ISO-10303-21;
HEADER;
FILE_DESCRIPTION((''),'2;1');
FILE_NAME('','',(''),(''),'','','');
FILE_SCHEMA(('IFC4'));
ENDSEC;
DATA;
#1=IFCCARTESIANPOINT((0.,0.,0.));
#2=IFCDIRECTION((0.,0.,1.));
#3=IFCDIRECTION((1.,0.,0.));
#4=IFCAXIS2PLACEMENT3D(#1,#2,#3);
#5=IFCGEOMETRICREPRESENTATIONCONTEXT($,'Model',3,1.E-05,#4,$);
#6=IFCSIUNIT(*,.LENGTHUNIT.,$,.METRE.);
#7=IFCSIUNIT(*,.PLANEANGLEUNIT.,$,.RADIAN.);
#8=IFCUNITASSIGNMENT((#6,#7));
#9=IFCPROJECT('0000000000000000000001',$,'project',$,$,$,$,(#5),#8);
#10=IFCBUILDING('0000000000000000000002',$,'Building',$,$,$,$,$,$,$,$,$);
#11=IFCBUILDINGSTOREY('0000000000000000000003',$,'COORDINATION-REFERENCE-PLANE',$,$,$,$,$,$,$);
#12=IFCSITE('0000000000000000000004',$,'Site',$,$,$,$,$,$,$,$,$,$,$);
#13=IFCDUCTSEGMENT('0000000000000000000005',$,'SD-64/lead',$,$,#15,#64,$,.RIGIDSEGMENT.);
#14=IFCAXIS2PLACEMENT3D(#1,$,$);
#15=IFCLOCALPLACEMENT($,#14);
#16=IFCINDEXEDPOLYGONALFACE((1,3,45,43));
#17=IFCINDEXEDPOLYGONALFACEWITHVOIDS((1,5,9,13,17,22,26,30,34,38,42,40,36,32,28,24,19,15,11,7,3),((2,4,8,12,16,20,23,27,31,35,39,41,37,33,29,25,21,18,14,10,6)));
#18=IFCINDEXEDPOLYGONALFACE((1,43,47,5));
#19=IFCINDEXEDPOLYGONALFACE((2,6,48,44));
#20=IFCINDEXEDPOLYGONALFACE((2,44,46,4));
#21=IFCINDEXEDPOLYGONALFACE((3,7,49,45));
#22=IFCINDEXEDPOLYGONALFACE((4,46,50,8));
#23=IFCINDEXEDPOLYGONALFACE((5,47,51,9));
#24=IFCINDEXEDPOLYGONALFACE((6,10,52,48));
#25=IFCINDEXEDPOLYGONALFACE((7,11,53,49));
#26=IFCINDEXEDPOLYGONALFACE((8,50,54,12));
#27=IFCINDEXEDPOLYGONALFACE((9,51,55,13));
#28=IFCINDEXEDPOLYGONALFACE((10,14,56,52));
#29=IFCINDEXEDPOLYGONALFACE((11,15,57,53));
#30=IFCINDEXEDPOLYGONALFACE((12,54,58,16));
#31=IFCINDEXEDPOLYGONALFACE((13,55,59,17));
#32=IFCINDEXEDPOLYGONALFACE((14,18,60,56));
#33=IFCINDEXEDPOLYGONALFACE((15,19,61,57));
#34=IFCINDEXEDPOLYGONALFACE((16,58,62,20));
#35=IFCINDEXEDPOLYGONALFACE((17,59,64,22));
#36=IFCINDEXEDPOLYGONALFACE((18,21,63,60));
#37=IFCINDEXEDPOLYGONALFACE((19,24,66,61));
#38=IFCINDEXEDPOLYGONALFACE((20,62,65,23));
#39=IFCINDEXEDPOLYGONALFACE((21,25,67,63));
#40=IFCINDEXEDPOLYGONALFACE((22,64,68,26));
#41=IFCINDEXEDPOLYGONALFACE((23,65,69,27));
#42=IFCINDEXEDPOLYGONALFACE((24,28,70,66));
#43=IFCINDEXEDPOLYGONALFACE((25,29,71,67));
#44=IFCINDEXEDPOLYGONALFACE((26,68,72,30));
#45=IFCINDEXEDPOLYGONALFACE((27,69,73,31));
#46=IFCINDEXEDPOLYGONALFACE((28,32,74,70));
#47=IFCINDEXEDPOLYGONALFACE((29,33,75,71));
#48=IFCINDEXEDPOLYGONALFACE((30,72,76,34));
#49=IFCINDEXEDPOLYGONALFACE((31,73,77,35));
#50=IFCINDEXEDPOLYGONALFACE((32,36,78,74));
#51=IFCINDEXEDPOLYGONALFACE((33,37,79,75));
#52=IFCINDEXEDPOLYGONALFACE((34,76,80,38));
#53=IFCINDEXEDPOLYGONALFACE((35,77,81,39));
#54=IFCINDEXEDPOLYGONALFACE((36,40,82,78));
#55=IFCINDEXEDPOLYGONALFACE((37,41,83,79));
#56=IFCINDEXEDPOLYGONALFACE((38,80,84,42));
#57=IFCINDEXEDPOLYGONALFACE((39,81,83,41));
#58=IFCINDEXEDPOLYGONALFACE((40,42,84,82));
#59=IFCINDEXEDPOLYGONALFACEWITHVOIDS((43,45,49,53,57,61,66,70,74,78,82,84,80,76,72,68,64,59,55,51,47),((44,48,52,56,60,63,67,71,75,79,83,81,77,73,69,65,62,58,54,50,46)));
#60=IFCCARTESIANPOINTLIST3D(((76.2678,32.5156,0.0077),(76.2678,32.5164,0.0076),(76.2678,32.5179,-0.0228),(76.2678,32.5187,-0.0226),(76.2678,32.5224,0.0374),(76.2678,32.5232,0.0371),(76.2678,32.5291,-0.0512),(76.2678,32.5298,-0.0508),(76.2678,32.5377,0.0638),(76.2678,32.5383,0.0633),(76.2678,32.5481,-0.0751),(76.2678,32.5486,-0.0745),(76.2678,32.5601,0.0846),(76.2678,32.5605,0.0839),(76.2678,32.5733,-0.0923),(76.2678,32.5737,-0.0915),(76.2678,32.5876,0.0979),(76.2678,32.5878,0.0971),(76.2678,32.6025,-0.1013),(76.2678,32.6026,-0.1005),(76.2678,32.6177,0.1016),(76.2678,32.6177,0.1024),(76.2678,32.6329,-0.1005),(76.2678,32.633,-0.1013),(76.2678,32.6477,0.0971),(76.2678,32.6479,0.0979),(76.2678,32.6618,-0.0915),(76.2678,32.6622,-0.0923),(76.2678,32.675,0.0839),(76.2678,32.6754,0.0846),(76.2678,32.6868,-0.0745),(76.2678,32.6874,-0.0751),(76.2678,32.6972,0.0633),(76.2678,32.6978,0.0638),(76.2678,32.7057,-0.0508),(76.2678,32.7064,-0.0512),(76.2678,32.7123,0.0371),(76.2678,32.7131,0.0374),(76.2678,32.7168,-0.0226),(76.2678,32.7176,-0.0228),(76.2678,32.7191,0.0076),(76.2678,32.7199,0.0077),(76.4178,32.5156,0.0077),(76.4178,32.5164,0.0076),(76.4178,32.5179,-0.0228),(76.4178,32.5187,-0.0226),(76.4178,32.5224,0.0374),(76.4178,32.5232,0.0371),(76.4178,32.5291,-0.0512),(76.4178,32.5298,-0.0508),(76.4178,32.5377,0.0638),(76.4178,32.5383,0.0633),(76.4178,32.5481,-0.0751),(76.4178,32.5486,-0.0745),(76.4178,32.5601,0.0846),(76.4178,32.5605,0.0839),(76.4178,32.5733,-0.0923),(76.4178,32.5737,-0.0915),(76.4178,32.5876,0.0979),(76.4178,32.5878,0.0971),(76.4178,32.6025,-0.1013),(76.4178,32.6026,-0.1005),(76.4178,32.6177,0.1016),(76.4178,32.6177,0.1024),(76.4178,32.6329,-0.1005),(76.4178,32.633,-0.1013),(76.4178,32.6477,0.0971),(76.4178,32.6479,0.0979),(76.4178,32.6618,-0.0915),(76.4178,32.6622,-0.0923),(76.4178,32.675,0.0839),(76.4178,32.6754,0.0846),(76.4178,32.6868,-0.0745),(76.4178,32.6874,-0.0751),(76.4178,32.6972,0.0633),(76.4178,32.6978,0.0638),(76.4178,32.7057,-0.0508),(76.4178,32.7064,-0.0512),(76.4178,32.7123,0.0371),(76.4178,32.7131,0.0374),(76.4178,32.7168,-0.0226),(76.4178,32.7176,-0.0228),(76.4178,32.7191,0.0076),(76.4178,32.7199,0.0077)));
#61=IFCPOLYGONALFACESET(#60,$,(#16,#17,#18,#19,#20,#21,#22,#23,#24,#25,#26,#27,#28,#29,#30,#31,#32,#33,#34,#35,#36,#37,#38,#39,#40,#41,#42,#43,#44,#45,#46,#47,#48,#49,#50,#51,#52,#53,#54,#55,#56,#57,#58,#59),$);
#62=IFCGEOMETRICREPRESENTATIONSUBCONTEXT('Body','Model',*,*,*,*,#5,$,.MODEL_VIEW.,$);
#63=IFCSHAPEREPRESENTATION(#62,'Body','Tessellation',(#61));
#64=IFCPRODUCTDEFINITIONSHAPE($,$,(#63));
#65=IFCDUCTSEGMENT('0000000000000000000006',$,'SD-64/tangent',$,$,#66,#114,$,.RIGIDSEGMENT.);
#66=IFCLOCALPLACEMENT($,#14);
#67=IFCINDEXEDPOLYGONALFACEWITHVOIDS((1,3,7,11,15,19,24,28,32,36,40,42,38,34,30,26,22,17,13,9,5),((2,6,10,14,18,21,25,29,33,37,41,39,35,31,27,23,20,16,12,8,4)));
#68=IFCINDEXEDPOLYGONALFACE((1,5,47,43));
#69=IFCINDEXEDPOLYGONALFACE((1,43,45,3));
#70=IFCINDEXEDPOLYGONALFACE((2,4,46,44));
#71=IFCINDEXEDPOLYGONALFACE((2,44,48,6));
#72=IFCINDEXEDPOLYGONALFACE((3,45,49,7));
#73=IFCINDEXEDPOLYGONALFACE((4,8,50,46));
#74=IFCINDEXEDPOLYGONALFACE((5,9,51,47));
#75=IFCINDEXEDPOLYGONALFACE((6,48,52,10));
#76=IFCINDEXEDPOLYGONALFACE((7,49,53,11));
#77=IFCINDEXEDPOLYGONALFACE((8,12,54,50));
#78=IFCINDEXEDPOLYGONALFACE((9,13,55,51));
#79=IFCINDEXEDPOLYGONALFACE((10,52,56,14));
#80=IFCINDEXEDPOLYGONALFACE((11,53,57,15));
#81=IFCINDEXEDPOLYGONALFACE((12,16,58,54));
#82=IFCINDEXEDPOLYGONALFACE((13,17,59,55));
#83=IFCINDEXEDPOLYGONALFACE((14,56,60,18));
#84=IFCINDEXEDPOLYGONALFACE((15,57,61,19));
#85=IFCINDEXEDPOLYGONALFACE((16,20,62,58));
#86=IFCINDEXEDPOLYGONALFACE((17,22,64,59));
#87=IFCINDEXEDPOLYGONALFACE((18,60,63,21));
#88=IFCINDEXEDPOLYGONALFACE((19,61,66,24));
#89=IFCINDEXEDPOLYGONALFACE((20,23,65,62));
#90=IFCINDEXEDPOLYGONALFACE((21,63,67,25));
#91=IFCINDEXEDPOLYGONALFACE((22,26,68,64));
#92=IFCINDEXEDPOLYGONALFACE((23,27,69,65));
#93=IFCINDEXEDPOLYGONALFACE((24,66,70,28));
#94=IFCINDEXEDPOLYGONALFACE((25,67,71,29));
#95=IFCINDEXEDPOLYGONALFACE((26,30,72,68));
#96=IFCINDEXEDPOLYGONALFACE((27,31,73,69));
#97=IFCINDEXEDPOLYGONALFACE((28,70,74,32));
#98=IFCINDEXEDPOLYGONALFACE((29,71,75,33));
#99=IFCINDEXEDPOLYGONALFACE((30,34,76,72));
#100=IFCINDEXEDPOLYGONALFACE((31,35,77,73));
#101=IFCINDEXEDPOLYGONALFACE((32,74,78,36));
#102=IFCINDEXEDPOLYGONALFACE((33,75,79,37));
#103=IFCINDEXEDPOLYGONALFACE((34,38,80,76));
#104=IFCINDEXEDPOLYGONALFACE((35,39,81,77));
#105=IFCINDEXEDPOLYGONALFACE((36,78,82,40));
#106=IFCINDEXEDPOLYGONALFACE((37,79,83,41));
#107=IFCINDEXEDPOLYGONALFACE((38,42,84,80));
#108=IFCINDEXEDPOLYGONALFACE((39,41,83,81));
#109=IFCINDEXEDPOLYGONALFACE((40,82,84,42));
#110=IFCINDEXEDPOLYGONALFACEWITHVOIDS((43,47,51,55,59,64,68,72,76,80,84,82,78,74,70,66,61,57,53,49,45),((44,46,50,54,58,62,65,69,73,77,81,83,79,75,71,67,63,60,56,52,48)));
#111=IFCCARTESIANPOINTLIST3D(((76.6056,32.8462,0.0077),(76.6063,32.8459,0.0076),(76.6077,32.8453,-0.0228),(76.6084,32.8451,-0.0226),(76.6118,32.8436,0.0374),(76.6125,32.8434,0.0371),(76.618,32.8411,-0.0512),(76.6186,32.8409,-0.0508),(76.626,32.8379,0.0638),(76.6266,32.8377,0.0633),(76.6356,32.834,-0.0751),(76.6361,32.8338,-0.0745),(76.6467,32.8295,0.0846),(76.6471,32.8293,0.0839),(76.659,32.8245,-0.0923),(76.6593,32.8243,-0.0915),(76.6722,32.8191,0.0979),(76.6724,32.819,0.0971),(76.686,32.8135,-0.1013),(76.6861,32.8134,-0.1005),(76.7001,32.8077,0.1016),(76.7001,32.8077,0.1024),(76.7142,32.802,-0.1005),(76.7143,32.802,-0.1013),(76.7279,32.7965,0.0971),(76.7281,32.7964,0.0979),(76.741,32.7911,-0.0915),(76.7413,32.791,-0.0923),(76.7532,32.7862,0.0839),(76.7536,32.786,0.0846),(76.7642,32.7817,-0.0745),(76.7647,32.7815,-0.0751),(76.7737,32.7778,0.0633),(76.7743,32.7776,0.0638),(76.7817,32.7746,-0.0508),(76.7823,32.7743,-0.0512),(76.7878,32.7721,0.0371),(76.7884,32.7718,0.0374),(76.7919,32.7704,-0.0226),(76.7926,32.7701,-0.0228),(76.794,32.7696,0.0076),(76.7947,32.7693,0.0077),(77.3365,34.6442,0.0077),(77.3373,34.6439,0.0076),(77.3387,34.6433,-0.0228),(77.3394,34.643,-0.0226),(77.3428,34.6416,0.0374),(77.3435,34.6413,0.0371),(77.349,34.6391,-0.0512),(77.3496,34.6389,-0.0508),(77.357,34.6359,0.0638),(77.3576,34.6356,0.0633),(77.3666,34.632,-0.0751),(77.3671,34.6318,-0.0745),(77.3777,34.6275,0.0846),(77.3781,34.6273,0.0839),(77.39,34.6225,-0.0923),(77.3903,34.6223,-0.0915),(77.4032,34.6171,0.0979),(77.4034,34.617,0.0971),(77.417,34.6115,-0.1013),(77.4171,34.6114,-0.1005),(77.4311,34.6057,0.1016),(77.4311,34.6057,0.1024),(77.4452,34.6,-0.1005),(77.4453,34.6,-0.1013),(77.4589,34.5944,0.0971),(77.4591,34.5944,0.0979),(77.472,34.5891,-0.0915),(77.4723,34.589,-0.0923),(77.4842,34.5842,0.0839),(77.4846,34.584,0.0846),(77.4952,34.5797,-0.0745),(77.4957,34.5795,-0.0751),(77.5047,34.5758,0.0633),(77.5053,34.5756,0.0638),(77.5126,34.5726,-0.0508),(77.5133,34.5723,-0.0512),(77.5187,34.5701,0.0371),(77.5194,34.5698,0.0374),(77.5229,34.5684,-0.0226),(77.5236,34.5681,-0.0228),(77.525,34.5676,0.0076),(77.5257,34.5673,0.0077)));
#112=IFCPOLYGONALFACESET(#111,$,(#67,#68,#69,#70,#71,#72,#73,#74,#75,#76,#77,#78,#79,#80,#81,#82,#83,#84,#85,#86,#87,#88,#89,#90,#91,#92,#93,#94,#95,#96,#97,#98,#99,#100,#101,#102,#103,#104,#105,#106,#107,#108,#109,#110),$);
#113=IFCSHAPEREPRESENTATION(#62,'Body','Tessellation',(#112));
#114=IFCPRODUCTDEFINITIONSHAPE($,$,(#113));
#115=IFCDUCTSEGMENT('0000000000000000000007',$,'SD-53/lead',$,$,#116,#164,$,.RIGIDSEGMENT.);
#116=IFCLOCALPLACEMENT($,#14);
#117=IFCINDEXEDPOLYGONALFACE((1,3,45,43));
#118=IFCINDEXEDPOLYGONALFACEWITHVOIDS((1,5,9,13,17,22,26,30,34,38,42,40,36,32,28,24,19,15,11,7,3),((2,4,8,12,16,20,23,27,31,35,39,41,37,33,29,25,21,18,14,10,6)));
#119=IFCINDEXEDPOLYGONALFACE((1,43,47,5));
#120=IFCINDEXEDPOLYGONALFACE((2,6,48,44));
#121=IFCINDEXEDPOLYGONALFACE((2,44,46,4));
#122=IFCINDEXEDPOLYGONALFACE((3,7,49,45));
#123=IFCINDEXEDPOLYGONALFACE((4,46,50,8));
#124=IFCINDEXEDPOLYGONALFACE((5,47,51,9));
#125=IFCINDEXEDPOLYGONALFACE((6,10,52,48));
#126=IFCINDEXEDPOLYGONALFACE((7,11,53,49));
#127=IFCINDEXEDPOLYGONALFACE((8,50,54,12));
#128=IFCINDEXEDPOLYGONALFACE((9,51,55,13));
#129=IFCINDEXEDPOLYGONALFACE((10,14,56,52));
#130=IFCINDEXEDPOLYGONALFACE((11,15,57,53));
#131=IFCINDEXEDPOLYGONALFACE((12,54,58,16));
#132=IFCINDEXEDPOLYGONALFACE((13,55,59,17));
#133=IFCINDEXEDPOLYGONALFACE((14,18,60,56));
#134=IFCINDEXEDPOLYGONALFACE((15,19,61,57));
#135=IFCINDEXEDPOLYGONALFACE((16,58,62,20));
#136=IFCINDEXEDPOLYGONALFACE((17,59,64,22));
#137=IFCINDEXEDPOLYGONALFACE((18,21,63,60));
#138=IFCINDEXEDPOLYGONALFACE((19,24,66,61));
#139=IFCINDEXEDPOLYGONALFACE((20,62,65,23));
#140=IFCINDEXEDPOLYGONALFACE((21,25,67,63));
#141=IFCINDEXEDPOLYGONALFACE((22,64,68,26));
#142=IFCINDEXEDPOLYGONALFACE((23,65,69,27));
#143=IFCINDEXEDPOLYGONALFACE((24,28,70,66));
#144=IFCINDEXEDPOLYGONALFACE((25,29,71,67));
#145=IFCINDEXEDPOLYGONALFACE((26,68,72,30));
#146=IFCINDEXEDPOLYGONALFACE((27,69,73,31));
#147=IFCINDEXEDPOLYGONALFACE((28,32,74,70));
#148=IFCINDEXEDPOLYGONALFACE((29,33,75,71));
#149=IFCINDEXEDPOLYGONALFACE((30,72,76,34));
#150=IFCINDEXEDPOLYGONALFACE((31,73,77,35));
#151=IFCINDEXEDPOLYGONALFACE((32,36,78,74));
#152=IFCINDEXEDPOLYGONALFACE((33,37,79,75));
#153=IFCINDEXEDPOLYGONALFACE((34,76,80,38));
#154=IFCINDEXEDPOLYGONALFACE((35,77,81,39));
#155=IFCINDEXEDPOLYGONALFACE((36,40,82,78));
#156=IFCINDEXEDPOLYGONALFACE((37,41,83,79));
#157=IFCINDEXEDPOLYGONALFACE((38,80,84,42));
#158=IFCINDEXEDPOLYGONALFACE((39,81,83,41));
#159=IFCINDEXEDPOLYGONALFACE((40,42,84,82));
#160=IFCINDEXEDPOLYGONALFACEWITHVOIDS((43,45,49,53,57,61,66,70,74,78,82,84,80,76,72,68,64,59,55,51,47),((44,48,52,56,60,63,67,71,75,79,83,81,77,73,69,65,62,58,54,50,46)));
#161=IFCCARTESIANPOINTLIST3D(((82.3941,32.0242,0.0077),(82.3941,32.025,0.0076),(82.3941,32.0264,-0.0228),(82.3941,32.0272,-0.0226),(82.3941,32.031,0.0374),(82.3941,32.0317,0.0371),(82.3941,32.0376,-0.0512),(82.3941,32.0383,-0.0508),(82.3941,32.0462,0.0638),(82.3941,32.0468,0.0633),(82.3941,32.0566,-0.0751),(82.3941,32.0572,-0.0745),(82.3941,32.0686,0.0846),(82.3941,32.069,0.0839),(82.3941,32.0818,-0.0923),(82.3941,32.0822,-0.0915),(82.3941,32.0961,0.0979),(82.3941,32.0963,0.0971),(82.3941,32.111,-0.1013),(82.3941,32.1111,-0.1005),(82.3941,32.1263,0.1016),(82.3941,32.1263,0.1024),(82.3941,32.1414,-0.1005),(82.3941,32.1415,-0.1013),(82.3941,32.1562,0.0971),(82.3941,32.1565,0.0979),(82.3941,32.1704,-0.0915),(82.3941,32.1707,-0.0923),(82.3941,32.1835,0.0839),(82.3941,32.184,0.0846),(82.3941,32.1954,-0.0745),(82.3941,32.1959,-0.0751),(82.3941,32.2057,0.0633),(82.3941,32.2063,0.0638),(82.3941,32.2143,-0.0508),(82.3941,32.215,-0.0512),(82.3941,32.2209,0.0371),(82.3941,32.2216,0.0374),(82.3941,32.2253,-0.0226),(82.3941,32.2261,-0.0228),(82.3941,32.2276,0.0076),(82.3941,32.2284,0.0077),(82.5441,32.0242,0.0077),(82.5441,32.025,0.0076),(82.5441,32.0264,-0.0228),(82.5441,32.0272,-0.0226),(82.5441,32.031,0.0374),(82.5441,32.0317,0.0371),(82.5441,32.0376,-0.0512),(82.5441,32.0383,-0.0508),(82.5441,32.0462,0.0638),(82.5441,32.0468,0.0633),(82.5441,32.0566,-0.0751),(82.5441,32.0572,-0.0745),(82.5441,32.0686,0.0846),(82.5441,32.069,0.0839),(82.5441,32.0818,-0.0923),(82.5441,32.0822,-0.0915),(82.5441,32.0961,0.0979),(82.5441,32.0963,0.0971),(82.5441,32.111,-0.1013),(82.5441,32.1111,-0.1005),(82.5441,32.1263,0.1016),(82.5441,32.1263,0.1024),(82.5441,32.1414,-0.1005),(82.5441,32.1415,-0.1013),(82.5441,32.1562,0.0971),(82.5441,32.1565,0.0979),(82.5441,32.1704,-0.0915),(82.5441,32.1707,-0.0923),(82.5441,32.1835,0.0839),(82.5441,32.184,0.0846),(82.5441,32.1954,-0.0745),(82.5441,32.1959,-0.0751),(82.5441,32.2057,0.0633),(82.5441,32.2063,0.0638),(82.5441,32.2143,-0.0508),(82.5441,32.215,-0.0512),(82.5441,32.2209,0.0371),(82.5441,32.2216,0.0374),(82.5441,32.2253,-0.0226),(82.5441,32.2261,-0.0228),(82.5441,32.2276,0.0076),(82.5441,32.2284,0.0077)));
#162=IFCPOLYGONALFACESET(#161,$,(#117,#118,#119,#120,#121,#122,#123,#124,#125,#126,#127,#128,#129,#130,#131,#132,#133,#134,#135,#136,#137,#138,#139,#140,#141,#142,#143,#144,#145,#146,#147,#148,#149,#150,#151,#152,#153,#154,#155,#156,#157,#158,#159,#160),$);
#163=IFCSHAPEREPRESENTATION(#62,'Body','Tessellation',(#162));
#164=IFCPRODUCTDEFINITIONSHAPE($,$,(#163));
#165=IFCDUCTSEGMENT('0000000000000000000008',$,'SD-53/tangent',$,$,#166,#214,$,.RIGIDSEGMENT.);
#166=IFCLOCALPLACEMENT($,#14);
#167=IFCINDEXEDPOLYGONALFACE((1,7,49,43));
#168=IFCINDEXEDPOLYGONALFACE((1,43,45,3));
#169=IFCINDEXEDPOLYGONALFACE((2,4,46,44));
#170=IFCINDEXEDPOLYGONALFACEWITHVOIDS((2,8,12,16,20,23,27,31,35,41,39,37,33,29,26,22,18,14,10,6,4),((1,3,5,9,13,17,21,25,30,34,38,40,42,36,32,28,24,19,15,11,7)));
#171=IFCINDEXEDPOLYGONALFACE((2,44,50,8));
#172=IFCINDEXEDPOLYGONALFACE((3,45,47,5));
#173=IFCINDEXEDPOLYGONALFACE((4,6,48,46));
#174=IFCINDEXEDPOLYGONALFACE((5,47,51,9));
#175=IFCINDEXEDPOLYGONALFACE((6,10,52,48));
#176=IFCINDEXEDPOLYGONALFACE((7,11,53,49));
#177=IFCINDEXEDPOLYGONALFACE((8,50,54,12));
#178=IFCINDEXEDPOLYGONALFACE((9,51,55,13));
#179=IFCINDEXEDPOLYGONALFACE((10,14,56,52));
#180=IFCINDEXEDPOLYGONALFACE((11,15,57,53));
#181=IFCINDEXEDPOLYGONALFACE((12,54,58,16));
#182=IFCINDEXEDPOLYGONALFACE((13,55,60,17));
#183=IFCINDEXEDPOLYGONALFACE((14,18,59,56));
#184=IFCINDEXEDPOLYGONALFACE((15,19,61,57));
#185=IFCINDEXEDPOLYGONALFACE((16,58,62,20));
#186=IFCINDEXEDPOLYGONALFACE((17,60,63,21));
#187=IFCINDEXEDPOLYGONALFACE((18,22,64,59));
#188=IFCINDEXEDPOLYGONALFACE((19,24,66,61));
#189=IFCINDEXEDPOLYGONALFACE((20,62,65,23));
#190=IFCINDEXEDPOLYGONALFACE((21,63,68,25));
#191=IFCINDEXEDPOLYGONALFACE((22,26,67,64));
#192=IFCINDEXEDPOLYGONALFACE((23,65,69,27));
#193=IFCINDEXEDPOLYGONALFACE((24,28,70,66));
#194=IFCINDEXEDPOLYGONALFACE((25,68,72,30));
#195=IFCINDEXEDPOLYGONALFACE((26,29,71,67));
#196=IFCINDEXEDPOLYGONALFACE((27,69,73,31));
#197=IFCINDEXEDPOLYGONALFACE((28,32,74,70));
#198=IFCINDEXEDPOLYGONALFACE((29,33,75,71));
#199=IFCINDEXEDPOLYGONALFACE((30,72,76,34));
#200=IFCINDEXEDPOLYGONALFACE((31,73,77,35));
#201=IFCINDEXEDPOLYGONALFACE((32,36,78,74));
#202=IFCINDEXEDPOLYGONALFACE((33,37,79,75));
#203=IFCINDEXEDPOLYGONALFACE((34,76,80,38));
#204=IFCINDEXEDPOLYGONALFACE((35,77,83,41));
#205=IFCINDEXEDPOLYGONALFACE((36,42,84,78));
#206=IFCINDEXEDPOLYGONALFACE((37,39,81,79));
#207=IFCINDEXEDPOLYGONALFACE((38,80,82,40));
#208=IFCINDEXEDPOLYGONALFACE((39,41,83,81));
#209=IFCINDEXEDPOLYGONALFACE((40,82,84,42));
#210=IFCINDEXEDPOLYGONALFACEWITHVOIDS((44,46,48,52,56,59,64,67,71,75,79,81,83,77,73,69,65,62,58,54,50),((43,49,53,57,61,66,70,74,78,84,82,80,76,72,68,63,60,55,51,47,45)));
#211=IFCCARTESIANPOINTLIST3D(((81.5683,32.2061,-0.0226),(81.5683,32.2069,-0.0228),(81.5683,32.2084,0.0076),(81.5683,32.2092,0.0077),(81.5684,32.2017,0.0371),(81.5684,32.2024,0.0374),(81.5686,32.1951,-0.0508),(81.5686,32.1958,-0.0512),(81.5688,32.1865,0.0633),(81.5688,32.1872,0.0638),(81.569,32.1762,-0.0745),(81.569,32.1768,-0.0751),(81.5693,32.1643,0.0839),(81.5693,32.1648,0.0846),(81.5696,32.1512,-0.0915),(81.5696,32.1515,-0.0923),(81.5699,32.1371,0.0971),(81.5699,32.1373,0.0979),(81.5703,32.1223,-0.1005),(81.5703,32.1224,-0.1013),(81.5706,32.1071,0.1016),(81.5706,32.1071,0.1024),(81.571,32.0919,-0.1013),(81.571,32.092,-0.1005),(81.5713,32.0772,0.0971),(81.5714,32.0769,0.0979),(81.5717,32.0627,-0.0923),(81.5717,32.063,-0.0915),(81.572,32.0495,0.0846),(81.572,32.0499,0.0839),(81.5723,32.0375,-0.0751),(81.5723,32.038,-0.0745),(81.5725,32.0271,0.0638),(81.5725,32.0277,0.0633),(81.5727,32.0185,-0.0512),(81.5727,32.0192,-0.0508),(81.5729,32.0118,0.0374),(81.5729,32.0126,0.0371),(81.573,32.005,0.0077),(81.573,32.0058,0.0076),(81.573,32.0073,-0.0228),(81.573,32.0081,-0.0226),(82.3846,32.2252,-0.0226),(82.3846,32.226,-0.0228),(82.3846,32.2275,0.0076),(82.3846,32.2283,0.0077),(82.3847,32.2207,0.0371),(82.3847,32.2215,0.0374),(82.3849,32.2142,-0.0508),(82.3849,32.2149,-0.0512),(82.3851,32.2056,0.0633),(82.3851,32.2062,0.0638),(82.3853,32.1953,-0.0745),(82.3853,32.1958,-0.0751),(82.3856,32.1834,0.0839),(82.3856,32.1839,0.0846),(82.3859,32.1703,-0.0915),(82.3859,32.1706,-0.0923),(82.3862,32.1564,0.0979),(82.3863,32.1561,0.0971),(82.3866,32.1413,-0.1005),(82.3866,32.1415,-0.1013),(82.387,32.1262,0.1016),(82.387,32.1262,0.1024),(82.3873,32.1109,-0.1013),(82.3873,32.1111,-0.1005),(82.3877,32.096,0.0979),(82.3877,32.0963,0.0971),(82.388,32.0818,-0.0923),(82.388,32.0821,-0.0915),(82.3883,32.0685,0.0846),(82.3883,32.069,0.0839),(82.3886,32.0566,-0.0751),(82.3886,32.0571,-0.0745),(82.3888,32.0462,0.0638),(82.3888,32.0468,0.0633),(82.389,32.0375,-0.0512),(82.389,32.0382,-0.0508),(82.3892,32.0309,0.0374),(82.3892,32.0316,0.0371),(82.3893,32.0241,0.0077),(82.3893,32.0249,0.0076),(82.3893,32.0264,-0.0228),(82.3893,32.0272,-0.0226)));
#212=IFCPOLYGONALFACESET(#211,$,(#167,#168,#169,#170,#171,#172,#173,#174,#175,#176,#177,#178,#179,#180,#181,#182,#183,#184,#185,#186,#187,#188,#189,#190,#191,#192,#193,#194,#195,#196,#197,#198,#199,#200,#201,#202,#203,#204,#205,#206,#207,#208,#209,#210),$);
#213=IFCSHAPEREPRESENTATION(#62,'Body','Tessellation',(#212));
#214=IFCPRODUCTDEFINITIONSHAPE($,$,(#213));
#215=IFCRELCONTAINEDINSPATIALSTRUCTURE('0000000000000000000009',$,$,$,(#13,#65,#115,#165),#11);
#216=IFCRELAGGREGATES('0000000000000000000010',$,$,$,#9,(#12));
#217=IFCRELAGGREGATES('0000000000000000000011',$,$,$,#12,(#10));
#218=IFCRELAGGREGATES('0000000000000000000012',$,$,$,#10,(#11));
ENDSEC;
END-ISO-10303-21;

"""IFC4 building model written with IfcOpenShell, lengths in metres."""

from ifc_helpers import new_model, si_unit, frame, origin_with_axes, place, context, subcontext, project, spatial, hollow_circle, extrude, element, save


model = new_model("IFC4")

# Units and contexts
model_context_1 = context("Model", 3, precision=1e-05, world=origin_with_axes())
body_context_1 = subcontext(model_context_1, "Body", "Model", "MODEL_VIEW")
ifc_project = project(units=[si_unit("LENGTHUNIT", "METRE"), si_unit("PLANEANGLEUNIT", "RADIAN")], contexts=[model_context_1])

# Site, building, storey
site = spatial("IfcSite", under=ifc_project, Name="Site")
building = spatial("IfcBuilding", under=site, Name="Building")
storey = spatial("IfcBuildingStorey", under=building, Name="COORDINATION-REFERENCE-PLANE")

# Duct segment
duct_segment_1_placement = place(None, frame((76.2678, 32.6177, 0.0), z_axis=(1.0, 0.0, 0.0), x_axis=(0.0, 0.0, 1.0)))
element("IfcDuctSegment", 1, at=duct_segment_1_placement, inside=storey, Name="SD-64/lead", PredefinedType="RIGIDSEGMENT", context=body_context_1, shape_type="SweptSolid", body=[
    extrude(hollow_circle(Radius=0.1024, WallThickness=0.0008), origin_with_axes(), (0.0, 0.0, 1.0), 0.15),
])

# Duct segment
duct_segment_2_placement = place(None, frame((76.7001, 32.8077, 0.0), z_axis=(0.376625, 0.926366, 0.0), x_axis=(0.0, 0.0, 1.0)))
element("IfcDuctSegment", 2, at=duct_segment_2_placement, inside=storey, Name="SD-64/tangent", PredefinedType="RIGIDSEGMENT", context=body_context_1, shape_type="SweptSolid", body=[
    extrude(hollow_circle(Radius=0.1024, WallThickness=0.0008), origin_with_axes(), (0.0, 0.0, 1.0), 1.9409),
])

# Duct segment
duct_segment_3_placement = place(None, frame((82.5441, 32.1263, 0.0), z_axis=(-1.0, 0.0, 0.0), x_axis=(0.0, 0.0, 1.0)))
element("IfcDuctSegment", 3, at=duct_segment_3_placement, inside=storey, Name="SD-53/lead", PredefinedType="RIGIDSEGMENT", context=body_context_1, shape_type="SweptSolid", body=[
    extrude(hollow_circle(Radius=0.1024, WallThickness=0.0008), origin_with_axes(), (0.0, 0.0, 1.0), 0.15),
])

# Duct segment
duct_segment_4_placement = place(None, frame((82.387, 32.1262, 0.0), z_axis=(-0.999727, -0.023361, 0.0), x_axis=(0.0, 0.0, 1.0)))
element("IfcDuctSegment", 4, at=duct_segment_4_placement, inside=storey, Name="SD-53/tangent", PredefinedType="RIGIDSEGMENT", context=body_context_1, shape_type="SweptSolid", body=[
    extrude(hollow_circle(Radius=0.1024, WallThickness=0.0008), origin_with_axes(), (0.0, 0.0, 1.0), 0.8165),
])

save(model, "model.ifc")
